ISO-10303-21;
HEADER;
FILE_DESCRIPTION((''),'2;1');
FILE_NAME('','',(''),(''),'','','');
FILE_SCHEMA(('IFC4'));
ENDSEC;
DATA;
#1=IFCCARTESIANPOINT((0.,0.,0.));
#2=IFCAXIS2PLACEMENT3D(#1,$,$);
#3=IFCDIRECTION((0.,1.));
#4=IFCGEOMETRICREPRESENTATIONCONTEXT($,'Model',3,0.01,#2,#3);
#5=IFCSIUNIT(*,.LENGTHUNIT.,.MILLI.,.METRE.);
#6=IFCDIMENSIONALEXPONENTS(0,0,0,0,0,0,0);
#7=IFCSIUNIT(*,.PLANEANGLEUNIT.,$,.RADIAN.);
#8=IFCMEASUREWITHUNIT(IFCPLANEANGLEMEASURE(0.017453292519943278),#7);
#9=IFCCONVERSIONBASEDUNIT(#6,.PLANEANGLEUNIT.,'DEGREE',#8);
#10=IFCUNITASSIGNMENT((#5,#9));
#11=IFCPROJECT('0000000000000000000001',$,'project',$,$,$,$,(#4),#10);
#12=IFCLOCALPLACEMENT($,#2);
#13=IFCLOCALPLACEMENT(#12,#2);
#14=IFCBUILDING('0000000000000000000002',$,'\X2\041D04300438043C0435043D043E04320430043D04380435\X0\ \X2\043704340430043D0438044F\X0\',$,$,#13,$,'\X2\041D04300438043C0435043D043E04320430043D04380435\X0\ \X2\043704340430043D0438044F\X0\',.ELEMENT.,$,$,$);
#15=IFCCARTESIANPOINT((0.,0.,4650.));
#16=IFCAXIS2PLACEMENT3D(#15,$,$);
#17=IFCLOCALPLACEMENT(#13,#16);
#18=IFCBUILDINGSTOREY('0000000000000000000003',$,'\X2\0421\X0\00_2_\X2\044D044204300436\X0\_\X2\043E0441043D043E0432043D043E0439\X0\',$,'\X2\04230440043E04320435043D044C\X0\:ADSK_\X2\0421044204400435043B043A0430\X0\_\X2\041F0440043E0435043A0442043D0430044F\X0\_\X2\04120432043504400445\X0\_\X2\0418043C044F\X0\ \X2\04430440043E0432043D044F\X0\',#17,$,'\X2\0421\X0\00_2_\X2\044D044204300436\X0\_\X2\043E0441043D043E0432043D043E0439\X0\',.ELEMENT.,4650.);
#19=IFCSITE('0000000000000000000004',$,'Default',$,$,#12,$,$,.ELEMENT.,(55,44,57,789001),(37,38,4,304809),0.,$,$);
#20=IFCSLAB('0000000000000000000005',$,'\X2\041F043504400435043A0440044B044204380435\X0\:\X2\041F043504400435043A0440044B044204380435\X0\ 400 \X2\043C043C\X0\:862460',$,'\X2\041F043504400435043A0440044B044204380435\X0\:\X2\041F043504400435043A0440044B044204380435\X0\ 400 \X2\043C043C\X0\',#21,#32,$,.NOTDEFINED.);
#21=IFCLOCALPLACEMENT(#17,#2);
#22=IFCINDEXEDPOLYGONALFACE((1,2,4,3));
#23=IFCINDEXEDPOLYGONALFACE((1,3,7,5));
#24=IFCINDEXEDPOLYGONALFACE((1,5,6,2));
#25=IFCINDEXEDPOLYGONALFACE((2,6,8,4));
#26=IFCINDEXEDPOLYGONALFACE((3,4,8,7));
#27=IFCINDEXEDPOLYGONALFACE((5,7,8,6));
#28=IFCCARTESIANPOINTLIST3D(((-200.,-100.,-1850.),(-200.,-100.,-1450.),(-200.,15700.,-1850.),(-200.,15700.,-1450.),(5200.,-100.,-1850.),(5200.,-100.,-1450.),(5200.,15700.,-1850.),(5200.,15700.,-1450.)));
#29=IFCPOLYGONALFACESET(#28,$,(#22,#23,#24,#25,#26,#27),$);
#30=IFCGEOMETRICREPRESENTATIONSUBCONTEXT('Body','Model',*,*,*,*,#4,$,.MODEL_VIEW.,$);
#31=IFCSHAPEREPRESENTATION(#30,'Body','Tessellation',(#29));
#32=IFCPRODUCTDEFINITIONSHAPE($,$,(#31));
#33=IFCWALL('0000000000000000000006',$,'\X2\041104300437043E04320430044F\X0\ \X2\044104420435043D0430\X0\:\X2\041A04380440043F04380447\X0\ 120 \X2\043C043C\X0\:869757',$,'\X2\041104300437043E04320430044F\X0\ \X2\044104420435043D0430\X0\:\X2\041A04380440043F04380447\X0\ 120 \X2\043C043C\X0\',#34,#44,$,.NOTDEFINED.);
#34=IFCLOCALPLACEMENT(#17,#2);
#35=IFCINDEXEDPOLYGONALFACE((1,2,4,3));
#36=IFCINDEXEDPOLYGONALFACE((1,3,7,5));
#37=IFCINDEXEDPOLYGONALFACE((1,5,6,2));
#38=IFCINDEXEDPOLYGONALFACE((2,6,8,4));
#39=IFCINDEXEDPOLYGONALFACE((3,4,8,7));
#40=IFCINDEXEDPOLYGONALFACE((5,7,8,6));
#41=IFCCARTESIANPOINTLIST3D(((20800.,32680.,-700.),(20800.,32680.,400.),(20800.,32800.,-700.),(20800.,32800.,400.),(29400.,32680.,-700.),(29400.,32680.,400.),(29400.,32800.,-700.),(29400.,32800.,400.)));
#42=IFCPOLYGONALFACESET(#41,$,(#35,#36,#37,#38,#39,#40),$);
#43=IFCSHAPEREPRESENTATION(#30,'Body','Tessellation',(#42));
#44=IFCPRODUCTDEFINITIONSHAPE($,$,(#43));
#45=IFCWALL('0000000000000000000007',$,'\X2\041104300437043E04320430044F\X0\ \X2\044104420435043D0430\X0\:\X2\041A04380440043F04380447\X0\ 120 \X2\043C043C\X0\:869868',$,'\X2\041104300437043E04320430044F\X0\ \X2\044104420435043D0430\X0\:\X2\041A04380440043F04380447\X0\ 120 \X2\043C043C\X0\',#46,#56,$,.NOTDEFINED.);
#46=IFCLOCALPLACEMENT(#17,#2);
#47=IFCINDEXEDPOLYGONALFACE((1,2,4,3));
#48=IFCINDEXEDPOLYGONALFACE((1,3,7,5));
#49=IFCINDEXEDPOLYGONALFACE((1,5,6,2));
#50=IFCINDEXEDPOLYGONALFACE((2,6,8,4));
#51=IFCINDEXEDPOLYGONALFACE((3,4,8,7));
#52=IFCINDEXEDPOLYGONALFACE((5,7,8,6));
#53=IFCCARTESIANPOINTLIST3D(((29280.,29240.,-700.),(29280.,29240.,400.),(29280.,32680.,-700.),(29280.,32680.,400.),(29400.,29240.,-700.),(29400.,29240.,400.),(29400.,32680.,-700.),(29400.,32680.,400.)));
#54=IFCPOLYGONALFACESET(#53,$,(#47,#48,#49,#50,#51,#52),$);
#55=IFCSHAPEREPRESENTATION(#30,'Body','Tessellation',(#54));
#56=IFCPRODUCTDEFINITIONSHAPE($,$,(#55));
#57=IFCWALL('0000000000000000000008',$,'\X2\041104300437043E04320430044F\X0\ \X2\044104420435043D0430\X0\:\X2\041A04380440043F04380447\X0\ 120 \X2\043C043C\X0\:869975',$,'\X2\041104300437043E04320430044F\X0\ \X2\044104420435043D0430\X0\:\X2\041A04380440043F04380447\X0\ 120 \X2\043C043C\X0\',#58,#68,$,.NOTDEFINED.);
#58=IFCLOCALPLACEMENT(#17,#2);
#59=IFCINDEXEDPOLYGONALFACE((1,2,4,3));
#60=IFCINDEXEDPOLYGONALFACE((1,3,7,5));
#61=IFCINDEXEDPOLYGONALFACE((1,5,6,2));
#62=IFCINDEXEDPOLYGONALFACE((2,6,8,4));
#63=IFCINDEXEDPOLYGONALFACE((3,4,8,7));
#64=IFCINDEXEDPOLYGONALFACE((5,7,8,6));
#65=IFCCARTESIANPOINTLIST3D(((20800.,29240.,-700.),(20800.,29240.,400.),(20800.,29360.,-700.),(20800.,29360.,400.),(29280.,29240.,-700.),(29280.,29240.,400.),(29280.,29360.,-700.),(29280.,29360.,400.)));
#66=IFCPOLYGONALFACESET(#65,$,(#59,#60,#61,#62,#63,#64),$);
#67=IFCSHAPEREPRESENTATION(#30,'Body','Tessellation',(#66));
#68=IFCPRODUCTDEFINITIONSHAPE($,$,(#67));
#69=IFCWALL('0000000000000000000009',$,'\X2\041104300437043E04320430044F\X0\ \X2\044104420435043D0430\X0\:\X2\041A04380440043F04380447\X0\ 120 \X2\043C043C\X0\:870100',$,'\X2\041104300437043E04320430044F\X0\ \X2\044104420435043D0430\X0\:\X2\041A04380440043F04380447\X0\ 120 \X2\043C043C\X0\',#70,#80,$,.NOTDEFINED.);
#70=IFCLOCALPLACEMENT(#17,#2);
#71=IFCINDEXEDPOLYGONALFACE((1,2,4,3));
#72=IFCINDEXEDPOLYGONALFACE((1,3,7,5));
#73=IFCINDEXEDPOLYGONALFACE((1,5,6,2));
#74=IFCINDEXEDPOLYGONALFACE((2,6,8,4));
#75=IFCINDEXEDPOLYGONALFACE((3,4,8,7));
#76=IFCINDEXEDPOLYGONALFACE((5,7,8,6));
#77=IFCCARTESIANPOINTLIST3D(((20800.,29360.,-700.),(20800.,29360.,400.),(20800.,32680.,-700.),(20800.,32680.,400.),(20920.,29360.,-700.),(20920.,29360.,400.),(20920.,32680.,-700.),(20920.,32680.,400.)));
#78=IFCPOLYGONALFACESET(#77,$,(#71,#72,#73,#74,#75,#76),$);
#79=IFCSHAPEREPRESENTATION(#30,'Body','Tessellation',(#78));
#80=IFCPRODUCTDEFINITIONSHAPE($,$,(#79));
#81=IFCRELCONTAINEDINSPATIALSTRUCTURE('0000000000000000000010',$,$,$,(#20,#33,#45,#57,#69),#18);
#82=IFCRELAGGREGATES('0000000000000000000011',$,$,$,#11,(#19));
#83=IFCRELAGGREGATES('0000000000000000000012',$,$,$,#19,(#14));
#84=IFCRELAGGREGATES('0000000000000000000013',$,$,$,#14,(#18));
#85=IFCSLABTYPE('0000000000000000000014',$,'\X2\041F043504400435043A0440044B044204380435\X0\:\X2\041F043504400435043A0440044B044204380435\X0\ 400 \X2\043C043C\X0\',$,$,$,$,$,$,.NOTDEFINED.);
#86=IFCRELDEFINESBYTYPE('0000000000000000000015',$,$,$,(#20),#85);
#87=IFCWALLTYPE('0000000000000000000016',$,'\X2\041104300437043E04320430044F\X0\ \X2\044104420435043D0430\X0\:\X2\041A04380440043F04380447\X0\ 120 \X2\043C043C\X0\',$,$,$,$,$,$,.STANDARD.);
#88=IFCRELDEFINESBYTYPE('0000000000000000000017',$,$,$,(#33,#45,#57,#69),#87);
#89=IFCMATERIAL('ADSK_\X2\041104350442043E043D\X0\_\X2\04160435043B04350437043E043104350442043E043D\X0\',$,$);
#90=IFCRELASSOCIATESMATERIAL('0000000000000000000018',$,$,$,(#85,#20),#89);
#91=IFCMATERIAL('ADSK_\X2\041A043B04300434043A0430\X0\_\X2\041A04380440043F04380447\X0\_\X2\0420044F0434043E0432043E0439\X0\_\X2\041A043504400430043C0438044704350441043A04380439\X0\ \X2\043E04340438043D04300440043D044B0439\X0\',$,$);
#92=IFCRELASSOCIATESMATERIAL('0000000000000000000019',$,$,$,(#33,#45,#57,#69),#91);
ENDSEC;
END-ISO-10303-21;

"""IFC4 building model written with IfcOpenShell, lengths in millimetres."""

from ifc_helpers import new_model, entity, si_unit, converted_unit, direction, frame, origin, place, context, subcontext, project, spatial, indexed_curve, outline, extrude, material, type_object, element, save


model = new_model("IFC4")

# Units and contexts
model_context = context("Model", 3, precision=0.01, world=origin(), true_north=direction((0.0, 1.0)))
body_context = subcontext(model_context, "Body", "Model", "MODEL_VIEW")
ifc_project = project(units=[si_unit("LENGTHUNIT", "METRE", prefix="MILLI"), converted_unit("PLANEANGLEUNIT", "DEGREE", entity("IfcPlaneAngleMeasure", 0.017453292519943278), si_unit("PLANEANGLEUNIT", "RADIAN"), dimensions=[0, 0, 0, 0, 0, 0, 0])], contexts=[model_context])

# Site, building, storey
site_placement = place(None, origin())
site = spatial("IfcSite", under=ifc_project, at=site_placement, Name="Default", CompositionType="ELEMENT", RefLatitude=(55, 44, 57, 789001), RefLongitude=(37, 38, 4, 304809), RefElevation=0.0)
building_placement = place(site_placement, origin())
building = spatial("IfcBuilding", under=site, at=building_placement, Name="Наименование здания", LongName="Наименование здания", CompositionType="ELEMENT")
storey_placement = place(building_placement, frame((0.0, 0.0, 4650.0)))
storey = spatial("IfcBuildingStorey", under=building, at=storey_placement, Name="С00_2_этаж_основной", ObjectType="Уровень:ADSK_Стрелка_Проектная_Вверх_Имя уровня", LongName="С00_2_этаж_основной", CompositionType="ELEMENT", Elevation=4650.0)

# Slab
ifc_material_1 = material(Name="ADSK_Бетон_Железобетон")
slab_type = type_object("IfcSlabType", Name="Перекрытие:Перекрытие 400 мм", PredefinedType="NOTDEFINED", material=ifc_material_1)
slab_placement = place(storey_placement, origin())
element("IfcSlab", 1, at=slab_placement, inside=storey, type_object=slab_type, material=ifc_material_1, Name="Перекрытие:Перекрытие 400 мм:862460", ObjectType="Перекрытие:Перекрытие 400 мм", PredefinedType="NOTDEFINED", context=body_context, shape_type="SweptSolid", body=[
    extrude(outline(indexed_curve([(-7900.0, -2700.0), (7900.0, -2700.0), (7900.0, 2700.0), (-7900.0, 2700.0), (-7900.0, -2700.0)], self_intersect=False)), frame((2500.0, 7800.0, -1450.0), z_axis=(0.0, 0.0, -1.0), x_axis=(0.0, 1.0, 0.0)), (0.0, 0.0, 1.0), 400.0),
])

# Walls
ifc_material_2 = material(Name="ADSK_Кладка_Кирпич_Рядовой_Керамический одинарный")
wall_type = type_object("IfcWallType", Name="Базовая стена:Кирпич 120 мм", PredefinedType="STANDARD")
wall_1_placement = place(storey_placement, frame((20800.0, 32740.0, -700.0)))
element("IfcWall", 2, at=wall_1_placement, inside=storey, type_object=wall_type, material=ifc_material_2, Name="Базовая стена:Кирпич 120 мм:869757", ObjectType="Базовая стена:Кирпич 120 мм", PredefinedType="NOTDEFINED", context=body_context, shape_type="SweptSolid", body=[
    extrude(outline(indexed_curve([(8600.0, 60.0), (0.0, 60.0), (0.0, -60.0), (8600.0, -60.0), (8600.0, 60.0)], self_intersect=False)), origin(), (0.0, 0.0, 1.0), 1100.0),
])
wall_2_placement = place(storey_placement, frame((29340.0, 32680.0, -700.0), z_axis=(0.0, 0.0, 1.0), x_axis=(0.0, -1.0, 0.0)))
element("IfcWall", 3, at=wall_2_placement, inside=storey, type_object=wall_type, material=ifc_material_2, Name="Базовая стена:Кирпич 120 мм:869868", ObjectType="Базовая стена:Кирпич 120 мм", PredefinedType="NOTDEFINED", context=body_context, shape_type="SweptSolid", body=[
    extrude(outline(indexed_curve([(3440.0, 60.0), (0.0, 60.0), (0.0, -60.0), (3440.0, -60.0), (3440.0, 60.0)], self_intersect=False)), origin(), (0.0, 0.0, 1.0), 1100.0),
])
wall_3_placement = place(storey_placement, frame((29280.0, 29300.0, -700.0), z_axis=(0.0, 0.0, 1.0), x_axis=(-1.0, 0.0, 0.0)))
element("IfcWall", 4, at=wall_3_placement, inside=storey, type_object=wall_type, material=ifc_material_2, Name="Базовая стена:Кирпич 120 мм:869975", ObjectType="Базовая стена:Кирпич 120 мм", PredefinedType="NOTDEFINED", context=body_context, shape_type="SweptSolid", body=[
    extrude(outline(indexed_curve([(8480.0, 60.0), (0.0, 60.0), (0.0, -60.0), (8480.0, -60.0), (8480.0, 60.0)], self_intersect=False)), origin(), (0.0, 0.0, 1.0), 1100.0),
])
wall_4_placement = place(storey_placement, frame((20860.0, 29360.0, -700.0), z_axis=(0.0, 0.0, 1.0), x_axis=(0.0, 1.0, 0.0)))
element("IfcWall", 5, at=wall_4_placement, inside=storey, type_object=wall_type, material=ifc_material_2, Name="Базовая стена:Кирпич 120 мм:870100", ObjectType="Базовая стена:Кирпич 120 мм", PredefinedType="NOTDEFINED", context=body_context, shape_type="SweptSolid", body=[
    extrude(outline(indexed_curve([(3320.0, 60.0), (0.0, 60.0), (0.0, -60.0), (3320.0, -60.0), (3320.0, 60.0)], self_intersect=False)), origin(), (0.0, 0.0, 1.0), 1100.0),
])

save(model, "model.ifc")
